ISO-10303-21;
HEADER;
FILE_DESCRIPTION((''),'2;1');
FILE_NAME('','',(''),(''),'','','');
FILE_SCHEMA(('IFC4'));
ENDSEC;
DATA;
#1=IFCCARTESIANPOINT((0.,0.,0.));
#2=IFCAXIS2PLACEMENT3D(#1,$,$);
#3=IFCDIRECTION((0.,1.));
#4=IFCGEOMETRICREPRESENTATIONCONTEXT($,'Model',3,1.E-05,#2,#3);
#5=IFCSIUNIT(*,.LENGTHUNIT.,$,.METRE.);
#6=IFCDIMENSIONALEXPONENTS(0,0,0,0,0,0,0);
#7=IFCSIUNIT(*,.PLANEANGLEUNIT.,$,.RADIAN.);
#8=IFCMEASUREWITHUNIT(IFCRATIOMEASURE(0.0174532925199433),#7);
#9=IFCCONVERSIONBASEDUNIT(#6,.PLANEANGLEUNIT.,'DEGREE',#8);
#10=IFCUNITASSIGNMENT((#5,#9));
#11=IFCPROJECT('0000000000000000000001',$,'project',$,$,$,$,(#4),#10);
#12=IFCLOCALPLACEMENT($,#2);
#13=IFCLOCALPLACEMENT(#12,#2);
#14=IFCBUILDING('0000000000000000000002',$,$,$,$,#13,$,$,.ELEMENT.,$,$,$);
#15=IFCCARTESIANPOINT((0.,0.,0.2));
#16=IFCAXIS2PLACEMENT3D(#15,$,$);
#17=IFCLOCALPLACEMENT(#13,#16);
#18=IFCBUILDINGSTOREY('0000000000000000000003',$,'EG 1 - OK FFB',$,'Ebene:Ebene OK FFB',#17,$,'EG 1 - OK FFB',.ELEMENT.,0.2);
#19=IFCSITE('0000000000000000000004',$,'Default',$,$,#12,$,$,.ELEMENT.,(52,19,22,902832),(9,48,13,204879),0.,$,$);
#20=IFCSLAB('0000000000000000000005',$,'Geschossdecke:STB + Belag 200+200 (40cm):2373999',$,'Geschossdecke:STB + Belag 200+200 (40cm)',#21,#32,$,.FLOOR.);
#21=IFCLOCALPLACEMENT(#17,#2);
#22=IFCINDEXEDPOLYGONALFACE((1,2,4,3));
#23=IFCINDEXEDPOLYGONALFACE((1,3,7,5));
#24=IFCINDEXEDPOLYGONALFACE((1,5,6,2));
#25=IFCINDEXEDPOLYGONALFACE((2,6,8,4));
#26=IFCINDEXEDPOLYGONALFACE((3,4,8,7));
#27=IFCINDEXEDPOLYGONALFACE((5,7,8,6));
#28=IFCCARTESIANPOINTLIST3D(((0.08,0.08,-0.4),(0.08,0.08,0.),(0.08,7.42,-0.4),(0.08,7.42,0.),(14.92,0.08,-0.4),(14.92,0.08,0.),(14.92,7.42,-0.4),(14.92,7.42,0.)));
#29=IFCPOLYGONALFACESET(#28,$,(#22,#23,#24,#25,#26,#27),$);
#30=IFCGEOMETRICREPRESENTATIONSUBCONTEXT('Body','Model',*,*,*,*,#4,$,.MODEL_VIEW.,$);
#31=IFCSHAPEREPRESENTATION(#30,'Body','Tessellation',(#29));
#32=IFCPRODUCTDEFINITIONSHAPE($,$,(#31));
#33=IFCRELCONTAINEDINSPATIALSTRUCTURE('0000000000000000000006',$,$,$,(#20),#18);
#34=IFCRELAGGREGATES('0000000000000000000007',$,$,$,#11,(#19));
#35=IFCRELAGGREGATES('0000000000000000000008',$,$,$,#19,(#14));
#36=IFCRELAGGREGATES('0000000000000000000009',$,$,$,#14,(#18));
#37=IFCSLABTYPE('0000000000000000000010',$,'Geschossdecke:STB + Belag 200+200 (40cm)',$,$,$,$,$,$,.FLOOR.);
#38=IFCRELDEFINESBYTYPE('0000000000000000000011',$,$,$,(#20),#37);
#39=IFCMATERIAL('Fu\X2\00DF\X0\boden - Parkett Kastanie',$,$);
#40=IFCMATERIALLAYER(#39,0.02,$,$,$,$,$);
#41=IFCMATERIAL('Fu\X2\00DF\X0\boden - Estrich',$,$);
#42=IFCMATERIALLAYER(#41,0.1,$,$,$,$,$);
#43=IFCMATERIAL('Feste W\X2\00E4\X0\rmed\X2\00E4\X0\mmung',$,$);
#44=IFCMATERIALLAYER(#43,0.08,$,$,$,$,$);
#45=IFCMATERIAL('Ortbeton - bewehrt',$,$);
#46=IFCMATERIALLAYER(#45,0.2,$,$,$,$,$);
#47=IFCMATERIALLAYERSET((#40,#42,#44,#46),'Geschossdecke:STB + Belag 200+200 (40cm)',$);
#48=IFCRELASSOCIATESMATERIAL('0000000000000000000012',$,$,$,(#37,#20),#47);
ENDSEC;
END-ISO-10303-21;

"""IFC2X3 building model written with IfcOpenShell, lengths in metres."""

from ifc_helpers import new_model, entity, si_unit, converted_unit, direction, frame, frame_2d, origin, place, context, subcontext, project, spatial, rectangle, extrude, material, layer, layer_set, layer_usage, type_object, element, save


model = new_model("IFC2X3")

# Units and contexts
model_context = context("Model", 3, precision=1e-05, world=origin(), true_north=direction((0.0, 1.0)))
body_context = subcontext(model_context, "Body", "Model", "MODEL_VIEW")
ifc_project = project(units=[si_unit("LENGTHUNIT", "METRE"), converted_unit("PLANEANGLEUNIT", "DEGREE", entity("IfcRatioMeasure", 0.0174532925199433), si_unit("PLANEANGLEUNIT", "RADIAN"), dimensions=[0, 0, 0, 0, 0, 0, 0])], contexts=[model_context])

# Site, building, storey
site_placement = place(None, frame((0.0, 0.0, 0.0)))
site = spatial("IfcSite", under=ifc_project, at=site_placement, Name="Default", CompositionType="ELEMENT", RefLatitude=(52, 19, 22, 902832), RefLongitude=(9, 48, 13, 204879), RefElevation=0.0)
building_placement = place(site_placement, origin())
building = spatial("IfcBuilding", under=site, at=building_placement, CompositionType="ELEMENT")
storey_placement = place(building_placement, frame((0.0, 0.0, 0.2)))
storey = spatial("IfcBuildingStorey", under=building, at=storey_placement, Name="EG 1 - OK FFB", ObjectType="Ebene:Ebene OK FFB", LongName="EG 1 - OK FFB", CompositionType="ELEMENT", Elevation=0.2)

# Slab
ifc_material_1 = material(Name="Fußboden - Parkett Kastanie")
ifc_layer_1 = layer(ifc_material_1, 0.02)
ifc_material_2 = material(Name="Fußboden - Estrich")
ifc_layer_2 = layer(ifc_material_2, 0.1)
ifc_material_3 = material(Name="Feste Wärmedämmung")
ifc_layer_3 = layer(ifc_material_3, 0.08)
ifc_material_4 = material(Name="Ortbeton - bewehrt")
ifc_layer_4 = layer(ifc_material_4, 0.2)
ifc_layer_set = layer_set([ifc_layer_1, ifc_layer_2, ifc_layer_3, ifc_layer_4], Name="Geschossdecke:STB + Belag 200+200 (40cm)")
ifc_layer_usage = layer_usage(ifc_layer_set, "AXIS3", "POSITIVE", 0.0)
slab_type = type_object("IfcSlabType", Name="Geschossdecke:STB + Belag 200+200 (40cm)", PredefinedType="FLOOR", material=ifc_layer_set)
slab_placement = place(storey_placement, origin())
element("IfcSlab", 1, at=slab_placement, inside=storey, type_object=slab_type, material=ifc_layer_usage, Name="Geschossdecke:STB + Belag 200+200 (40cm):2373999", ObjectType="Geschossdecke:STB + Belag 200+200 (40cm)", PredefinedType="FLOOR", context=body_context, shape_type="SweptSolid", body=[
    extrude(rectangle(XDim=7.34, YDim=14.84, at=frame_2d((0.0, 0.0), x_axis=(1.0, 0.0))), frame((7.5, 3.75, 0.0), z_axis=(0.0, 0.0, -1.0), x_axis=(0.0, 1.0, 0.0)), (0.0, 0.0, 1.0), 0.4),
])

save(model, "model.ifc")
